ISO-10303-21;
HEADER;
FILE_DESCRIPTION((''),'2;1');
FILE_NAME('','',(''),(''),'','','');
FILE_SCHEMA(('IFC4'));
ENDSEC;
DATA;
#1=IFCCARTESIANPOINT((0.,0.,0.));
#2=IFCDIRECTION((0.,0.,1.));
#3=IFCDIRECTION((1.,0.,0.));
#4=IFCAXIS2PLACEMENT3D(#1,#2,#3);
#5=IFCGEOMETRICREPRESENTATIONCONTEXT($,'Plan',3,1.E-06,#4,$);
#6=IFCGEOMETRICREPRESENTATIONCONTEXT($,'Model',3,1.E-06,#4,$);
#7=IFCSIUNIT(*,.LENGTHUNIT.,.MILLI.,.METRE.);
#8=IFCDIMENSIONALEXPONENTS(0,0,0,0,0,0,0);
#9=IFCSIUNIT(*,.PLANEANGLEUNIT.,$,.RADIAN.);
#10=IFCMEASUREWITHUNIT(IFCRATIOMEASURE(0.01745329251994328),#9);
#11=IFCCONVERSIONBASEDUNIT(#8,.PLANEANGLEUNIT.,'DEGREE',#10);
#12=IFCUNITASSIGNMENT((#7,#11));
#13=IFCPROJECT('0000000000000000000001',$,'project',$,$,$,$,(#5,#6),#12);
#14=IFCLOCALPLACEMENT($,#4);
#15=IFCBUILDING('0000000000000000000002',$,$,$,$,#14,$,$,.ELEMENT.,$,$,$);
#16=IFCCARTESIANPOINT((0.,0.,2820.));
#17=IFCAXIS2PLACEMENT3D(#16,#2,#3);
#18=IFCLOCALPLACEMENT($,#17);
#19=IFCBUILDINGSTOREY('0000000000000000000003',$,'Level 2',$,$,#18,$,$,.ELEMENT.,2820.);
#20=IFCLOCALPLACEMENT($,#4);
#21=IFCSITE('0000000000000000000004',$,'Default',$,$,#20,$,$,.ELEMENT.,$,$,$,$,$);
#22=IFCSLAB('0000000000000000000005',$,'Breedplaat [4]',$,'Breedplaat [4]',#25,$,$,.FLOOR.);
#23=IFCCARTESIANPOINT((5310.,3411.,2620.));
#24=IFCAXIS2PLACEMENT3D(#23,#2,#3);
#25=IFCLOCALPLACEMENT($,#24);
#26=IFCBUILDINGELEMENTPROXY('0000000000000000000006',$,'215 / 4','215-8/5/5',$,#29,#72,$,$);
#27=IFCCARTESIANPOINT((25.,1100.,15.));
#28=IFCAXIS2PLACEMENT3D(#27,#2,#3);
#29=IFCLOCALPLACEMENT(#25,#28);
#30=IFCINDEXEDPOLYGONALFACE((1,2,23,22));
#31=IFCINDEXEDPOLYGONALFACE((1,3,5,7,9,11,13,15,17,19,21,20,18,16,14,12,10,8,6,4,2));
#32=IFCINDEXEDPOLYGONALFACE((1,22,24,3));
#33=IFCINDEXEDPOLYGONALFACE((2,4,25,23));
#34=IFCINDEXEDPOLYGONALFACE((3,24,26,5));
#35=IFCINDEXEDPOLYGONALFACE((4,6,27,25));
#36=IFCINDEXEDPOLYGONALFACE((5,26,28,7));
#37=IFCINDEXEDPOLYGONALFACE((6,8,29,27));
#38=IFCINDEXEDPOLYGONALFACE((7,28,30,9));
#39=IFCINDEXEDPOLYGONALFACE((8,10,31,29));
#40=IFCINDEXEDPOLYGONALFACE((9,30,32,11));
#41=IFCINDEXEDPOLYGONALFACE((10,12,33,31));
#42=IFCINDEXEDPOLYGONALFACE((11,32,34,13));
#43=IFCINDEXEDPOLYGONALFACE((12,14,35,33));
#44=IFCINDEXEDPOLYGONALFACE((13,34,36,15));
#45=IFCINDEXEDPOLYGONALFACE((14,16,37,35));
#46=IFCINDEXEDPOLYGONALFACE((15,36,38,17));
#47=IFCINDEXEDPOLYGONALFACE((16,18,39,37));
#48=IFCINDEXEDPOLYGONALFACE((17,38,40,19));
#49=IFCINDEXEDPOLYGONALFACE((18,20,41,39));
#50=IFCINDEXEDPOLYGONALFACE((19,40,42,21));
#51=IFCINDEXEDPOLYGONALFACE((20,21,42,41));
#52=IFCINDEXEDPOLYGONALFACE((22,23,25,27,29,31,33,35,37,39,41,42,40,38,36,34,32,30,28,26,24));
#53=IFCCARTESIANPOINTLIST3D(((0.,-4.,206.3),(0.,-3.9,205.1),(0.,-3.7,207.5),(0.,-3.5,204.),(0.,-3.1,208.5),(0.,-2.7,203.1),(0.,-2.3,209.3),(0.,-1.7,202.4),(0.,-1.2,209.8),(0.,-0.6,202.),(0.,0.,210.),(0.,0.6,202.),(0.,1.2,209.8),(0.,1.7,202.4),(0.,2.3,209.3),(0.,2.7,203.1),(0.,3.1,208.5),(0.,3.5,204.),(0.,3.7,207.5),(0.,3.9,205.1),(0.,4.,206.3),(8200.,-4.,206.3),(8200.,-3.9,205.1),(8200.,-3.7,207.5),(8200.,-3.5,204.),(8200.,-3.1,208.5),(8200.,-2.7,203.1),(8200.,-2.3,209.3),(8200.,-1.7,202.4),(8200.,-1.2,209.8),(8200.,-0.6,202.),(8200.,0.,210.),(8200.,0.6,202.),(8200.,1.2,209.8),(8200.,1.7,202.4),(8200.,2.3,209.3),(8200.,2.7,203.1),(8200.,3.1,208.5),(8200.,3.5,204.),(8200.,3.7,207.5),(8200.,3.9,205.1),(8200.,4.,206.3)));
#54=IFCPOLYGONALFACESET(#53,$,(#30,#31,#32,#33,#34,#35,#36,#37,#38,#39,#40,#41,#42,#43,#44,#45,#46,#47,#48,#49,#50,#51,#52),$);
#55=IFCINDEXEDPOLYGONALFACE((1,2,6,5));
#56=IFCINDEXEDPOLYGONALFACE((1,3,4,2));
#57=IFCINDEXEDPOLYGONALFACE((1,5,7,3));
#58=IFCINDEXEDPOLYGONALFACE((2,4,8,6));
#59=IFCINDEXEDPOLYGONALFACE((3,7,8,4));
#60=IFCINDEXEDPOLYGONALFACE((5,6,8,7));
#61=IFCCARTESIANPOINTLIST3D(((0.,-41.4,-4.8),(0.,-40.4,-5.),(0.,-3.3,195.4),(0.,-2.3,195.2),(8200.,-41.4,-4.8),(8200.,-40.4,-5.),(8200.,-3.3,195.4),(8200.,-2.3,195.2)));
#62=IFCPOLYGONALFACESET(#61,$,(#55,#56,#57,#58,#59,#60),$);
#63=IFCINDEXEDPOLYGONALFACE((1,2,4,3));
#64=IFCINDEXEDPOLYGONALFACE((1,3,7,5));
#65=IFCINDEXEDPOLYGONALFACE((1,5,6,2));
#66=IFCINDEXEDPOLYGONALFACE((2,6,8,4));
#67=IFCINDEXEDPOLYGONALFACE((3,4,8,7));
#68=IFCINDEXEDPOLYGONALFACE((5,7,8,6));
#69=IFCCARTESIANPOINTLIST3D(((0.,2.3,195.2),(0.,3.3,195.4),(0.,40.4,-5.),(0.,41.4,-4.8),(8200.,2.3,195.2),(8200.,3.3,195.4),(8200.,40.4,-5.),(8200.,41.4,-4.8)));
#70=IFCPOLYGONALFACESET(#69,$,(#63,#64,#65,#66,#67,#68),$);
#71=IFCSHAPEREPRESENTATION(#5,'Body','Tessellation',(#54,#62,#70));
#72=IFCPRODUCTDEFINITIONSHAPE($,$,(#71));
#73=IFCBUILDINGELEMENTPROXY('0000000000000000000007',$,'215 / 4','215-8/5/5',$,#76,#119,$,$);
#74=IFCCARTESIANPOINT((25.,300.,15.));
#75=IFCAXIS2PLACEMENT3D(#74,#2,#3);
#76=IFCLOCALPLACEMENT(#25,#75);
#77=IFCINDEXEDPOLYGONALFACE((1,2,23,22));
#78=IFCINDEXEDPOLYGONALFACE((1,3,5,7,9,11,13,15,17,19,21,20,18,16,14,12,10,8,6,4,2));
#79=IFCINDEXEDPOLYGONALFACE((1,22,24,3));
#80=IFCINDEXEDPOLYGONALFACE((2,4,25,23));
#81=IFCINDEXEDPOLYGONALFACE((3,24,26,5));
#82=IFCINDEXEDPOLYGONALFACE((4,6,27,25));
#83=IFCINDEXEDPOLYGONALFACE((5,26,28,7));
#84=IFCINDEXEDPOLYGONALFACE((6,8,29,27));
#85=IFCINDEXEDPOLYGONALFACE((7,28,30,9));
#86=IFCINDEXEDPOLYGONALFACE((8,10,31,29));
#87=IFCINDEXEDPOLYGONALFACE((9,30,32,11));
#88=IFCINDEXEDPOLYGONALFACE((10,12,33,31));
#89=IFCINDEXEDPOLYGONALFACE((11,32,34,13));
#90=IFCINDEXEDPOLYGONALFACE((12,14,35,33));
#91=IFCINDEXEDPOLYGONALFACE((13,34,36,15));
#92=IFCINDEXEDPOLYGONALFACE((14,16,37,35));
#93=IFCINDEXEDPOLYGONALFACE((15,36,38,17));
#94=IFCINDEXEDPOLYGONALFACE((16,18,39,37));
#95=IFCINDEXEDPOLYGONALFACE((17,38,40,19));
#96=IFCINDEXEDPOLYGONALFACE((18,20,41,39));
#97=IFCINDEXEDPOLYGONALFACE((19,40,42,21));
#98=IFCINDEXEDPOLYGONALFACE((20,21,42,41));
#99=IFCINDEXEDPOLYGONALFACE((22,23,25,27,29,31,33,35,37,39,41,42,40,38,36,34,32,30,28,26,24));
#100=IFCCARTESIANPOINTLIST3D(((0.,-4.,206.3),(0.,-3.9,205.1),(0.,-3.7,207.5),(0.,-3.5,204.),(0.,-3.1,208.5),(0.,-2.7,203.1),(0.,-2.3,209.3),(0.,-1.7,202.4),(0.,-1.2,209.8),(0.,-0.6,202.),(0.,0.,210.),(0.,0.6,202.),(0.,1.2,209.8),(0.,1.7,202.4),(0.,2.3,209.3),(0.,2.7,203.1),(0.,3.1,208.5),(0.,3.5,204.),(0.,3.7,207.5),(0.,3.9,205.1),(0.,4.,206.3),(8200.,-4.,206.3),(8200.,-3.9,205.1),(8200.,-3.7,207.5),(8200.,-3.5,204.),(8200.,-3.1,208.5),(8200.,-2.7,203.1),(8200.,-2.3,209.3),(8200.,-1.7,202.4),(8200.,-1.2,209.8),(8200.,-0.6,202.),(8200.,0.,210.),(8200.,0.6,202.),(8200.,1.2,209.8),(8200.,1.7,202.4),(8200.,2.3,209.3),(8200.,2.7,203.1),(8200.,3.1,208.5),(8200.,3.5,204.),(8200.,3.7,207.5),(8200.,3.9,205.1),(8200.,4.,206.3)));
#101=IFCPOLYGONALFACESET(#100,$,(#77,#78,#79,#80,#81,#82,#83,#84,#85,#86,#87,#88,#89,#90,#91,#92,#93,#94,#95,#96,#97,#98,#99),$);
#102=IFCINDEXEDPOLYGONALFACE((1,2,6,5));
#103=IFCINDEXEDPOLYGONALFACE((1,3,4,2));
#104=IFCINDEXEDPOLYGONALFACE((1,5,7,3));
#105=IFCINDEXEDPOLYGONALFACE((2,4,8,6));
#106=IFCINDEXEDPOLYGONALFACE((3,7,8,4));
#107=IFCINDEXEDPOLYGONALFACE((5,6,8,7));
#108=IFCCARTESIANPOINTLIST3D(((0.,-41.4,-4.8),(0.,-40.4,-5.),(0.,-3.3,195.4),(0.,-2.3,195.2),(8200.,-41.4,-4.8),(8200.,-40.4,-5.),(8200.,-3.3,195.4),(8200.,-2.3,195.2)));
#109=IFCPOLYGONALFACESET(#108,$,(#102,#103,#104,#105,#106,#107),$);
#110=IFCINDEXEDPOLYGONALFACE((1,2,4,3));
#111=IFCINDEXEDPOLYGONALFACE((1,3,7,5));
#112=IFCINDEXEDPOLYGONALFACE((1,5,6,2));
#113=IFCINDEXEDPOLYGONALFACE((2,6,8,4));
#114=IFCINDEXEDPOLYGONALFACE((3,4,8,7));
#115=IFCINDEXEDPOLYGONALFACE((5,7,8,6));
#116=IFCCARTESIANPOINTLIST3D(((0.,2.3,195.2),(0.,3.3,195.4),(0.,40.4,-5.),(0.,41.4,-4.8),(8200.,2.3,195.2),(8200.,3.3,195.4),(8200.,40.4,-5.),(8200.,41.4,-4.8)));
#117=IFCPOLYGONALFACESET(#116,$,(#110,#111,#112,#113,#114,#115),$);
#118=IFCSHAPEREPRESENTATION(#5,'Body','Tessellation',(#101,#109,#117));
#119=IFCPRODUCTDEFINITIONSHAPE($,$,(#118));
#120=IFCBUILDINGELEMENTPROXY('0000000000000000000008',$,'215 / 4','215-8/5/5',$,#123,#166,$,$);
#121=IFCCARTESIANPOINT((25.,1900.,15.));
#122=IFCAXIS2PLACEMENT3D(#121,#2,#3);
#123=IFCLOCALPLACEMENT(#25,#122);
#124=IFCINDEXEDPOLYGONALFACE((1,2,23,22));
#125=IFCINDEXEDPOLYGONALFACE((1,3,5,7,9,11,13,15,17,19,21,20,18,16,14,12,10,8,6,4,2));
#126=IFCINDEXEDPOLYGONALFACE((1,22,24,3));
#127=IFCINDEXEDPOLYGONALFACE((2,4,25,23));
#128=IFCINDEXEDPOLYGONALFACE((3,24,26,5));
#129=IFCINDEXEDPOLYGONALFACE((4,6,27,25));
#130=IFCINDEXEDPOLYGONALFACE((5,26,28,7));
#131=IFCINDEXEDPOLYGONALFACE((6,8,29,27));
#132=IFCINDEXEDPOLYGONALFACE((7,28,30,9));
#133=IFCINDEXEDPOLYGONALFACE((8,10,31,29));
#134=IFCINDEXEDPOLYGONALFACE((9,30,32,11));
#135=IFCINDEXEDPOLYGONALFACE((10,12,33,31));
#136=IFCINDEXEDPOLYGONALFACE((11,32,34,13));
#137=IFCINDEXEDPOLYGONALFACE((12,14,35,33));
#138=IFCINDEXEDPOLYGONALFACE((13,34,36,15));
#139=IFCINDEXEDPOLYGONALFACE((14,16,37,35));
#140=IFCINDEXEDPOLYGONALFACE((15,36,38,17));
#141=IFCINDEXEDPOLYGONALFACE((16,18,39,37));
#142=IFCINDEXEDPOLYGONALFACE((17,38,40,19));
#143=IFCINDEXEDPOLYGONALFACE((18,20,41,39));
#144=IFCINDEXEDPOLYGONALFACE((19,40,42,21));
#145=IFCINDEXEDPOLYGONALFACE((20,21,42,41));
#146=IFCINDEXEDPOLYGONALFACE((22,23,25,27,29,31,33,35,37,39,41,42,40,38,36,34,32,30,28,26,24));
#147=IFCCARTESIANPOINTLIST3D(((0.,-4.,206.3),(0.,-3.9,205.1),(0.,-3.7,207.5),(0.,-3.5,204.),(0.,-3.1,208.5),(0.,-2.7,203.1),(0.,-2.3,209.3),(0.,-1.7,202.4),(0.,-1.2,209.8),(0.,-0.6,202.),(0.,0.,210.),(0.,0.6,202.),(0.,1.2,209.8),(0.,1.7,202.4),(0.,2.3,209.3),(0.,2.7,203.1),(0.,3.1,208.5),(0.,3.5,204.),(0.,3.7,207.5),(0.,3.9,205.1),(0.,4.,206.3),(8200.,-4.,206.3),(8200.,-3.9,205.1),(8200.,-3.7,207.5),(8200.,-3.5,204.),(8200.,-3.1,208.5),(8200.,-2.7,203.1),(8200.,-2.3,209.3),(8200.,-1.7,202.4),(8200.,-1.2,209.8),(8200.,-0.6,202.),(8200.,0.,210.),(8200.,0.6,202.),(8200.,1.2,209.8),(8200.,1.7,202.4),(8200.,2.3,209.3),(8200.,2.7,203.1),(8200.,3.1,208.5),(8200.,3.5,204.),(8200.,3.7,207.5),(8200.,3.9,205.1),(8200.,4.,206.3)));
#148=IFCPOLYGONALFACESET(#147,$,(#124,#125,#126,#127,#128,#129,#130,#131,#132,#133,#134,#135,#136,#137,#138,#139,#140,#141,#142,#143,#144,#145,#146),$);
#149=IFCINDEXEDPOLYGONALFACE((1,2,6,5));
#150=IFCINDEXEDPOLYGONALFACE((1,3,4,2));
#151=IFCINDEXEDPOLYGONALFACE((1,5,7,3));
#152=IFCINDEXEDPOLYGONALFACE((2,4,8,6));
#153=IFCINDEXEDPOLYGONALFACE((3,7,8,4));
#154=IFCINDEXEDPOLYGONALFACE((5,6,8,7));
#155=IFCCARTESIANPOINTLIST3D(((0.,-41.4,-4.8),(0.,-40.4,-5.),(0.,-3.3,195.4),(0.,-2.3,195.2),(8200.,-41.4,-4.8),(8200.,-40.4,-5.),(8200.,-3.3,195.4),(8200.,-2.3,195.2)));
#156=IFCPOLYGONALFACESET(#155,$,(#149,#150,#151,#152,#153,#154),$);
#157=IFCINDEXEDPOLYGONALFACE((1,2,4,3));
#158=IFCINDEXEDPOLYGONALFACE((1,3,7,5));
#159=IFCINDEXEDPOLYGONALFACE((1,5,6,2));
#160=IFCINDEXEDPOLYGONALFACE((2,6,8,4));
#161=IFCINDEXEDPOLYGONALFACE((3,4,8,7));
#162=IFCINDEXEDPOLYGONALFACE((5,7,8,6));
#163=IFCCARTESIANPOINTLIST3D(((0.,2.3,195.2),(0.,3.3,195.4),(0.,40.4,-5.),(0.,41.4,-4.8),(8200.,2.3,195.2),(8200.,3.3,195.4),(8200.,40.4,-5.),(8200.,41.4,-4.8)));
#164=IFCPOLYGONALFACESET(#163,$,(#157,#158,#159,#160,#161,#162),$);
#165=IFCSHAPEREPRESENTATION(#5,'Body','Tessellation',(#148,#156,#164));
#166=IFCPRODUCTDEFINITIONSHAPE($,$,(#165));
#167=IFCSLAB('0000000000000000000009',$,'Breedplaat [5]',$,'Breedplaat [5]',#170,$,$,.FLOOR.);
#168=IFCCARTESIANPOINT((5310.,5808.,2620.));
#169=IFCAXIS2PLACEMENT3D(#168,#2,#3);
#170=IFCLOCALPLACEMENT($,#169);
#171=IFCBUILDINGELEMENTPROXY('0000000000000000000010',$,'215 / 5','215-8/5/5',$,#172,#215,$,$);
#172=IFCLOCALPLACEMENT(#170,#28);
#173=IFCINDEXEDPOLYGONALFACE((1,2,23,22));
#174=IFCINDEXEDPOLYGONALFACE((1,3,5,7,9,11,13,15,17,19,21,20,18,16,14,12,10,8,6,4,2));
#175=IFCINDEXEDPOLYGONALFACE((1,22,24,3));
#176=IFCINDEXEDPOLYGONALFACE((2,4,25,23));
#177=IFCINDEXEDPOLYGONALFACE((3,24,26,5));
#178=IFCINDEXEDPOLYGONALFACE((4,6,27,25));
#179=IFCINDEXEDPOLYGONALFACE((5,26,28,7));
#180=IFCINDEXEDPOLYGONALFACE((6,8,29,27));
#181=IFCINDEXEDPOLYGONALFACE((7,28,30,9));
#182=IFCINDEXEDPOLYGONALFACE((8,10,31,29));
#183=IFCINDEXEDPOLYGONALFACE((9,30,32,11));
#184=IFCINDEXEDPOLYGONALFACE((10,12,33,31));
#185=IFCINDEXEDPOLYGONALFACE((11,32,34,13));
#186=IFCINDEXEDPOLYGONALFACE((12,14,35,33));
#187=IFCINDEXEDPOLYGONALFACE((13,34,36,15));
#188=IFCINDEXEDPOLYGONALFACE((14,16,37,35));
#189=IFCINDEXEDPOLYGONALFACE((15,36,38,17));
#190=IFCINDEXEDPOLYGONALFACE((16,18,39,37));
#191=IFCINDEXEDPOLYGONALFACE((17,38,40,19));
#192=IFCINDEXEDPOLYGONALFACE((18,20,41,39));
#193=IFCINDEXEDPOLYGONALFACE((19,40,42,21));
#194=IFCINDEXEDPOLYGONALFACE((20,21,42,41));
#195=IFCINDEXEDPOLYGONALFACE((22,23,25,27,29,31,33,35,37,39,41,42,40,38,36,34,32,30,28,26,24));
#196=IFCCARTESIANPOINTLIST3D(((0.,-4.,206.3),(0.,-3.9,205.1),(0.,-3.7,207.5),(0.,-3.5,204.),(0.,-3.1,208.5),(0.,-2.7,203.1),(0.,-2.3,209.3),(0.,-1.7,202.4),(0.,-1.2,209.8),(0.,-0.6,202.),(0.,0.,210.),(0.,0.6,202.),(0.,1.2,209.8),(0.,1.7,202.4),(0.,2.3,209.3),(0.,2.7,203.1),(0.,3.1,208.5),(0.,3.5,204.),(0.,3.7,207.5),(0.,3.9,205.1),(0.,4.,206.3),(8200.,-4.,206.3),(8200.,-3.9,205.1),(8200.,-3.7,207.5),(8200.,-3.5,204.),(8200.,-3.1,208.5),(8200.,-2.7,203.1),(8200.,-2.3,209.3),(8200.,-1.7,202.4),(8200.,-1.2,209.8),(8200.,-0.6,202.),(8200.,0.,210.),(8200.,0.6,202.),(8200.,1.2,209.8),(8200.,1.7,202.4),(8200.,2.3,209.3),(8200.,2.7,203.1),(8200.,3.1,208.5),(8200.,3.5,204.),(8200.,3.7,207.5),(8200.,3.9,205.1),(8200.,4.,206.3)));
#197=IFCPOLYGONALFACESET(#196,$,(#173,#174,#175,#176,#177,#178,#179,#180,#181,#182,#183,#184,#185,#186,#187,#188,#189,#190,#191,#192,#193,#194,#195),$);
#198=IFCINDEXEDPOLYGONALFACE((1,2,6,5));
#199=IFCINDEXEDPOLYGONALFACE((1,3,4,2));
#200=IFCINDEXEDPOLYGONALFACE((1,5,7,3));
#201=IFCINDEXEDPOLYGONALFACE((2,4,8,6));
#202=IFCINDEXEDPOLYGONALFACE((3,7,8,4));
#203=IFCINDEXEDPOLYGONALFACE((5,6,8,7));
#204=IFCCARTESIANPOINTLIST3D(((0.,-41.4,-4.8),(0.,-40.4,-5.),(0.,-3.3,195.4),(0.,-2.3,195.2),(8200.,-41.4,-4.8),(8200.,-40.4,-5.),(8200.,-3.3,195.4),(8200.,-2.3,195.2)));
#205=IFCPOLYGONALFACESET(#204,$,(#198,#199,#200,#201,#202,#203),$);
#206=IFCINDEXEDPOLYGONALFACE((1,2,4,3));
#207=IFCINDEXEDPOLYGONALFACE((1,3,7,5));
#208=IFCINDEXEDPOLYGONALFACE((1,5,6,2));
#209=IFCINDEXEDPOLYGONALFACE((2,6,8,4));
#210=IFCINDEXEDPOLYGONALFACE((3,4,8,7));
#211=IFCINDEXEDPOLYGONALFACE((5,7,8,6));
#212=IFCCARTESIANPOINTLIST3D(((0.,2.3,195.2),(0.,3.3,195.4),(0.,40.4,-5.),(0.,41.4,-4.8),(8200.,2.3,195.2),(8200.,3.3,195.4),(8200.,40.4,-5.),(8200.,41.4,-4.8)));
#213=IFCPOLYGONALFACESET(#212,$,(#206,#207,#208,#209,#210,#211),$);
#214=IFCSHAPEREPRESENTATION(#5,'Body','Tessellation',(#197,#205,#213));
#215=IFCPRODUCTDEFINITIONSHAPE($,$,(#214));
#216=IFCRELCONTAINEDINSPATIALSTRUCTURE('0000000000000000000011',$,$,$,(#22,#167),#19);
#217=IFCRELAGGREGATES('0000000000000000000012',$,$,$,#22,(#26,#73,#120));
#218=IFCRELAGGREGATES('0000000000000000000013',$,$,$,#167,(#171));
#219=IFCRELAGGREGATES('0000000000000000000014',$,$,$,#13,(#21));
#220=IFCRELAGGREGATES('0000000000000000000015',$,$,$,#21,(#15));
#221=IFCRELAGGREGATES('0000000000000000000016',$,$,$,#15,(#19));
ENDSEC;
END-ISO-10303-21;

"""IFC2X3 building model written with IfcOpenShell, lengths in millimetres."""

from ifc_helpers import new_model, entity, si_unit, converted_unit, frame, origin_with_axes, origin_2d_with_axis, place, context, project, spatial, rectangle, circle, extrude, element, aggregate, save


model = new_model("IFC2X3")

# Units and contexts
plan_context = context("Plan", 3, precision=1e-06, world=origin_with_axes())
model_context = context("Model", 3, precision=1e-06, world=origin_with_axes())
ifc_project = project(units=[si_unit("LENGTHUNIT", "METRE", prefix="MILLI"), converted_unit("PLANEANGLEUNIT", "DEGREE", entity("IfcRatioMeasure", 0.01745329251994328), si_unit("PLANEANGLEUNIT", "RADIAN"), dimensions=[0, 0, 0, 0, 0, 0, 0])], contexts=[plan_context, model_context])

# Site, building, storey
site_placement = place(None, origin_with_axes())
site = spatial("IfcSite", under=ifc_project, at=site_placement, Name="Default", CompositionType="ELEMENT")
building_placement = place(None, origin_with_axes())
building = spatial("IfcBuilding", under=site, at=building_placement, CompositionType="ELEMENT")
storey_placement = place(None, frame((0.0, 0.0, 2820.0), z_axis=(0.0, 0.0, 1.0), x_axis=(1.0, 0.0, 0.0)))
storey = spatial("IfcBuildingStorey", under=building, at=storey_placement, Name="Level 2", CompositionType="ELEMENT", Elevation=2820.0)

# Slabs, building element proxies
slab_1_placement = place(None, frame((5310.0, 3411.0, 2620.0), z_axis=(0.0, 0.0, 1.0), x_axis=(1.0, 0.0, 0.0)))
slab_1 = element("IfcSlab", 1, at=slab_1_placement, inside=storey, Name="Breedplaat [4]", ObjectType="Breedplaat [4]", PredefinedType="FLOOR")
proxy_1_placement = place(slab_1_placement, frame((25.0, 1100.0, 15.0), z_axis=(0.0, 0.0, 1.0), x_axis=(1.0, 0.0, 0.0)))
proxy_1 = element("IfcBuildingElementProxy", 2, at=proxy_1_placement, Name="215 / 4", Description="215-8/5/5", context=plan_context, shape_type="SweptSolid", body=[
    extrude(circle(Radius=4.0, at=origin_2d_with_axis()), frame((0.0, 0.0, 206.0), z_axis=(1.0, 0.0, 0.0), x_axis=(0.0, 0.0, 1.0)), (0.0, 0.0, 1.0), 8200.0),
    extrude(rectangle(XDim=203.8, YDim=1.0, at=origin_2d_with_axis()), frame((0.0, -21.9, 95.2), z_axis=(1.0, 0.0, 0.0), x_axis=(0.0, 0.187112, 0.982339)), (0.0, 0.0, 1.0), 8200.0),
    extrude(rectangle(XDim=203.8, YDim=1.0, at=origin_2d_with_axis()), frame((0.0, 21.9, 95.2), z_axis=(1.0, 0.0, 0.0), x_axis=(0.0, -0.187112, 0.982339)), (0.0, 0.0, 1.0), 8200.0),
])
proxy_2_placement = place(slab_1_placement, frame((25.0, 300.0, 15.0), z_axis=(0.0, 0.0, 1.0), x_axis=(1.0, 0.0, 0.0)))
proxy_2 = element("IfcBuildingElementProxy", 3, at=proxy_2_placement, Name="215 / 4", Description="215-8/5/5", context=plan_context, shape_type="SweptSolid", body=[
    extrude(circle(Radius=4.0, at=origin_2d_with_axis()), frame((0.0, 0.0, 206.0), z_axis=(1.0, 0.0, 0.0), x_axis=(0.0, 0.0, 1.0)), (0.0, 0.0, 1.0), 8200.0),
    extrude(rectangle(XDim=203.8, YDim=1.0, at=origin_2d_with_axis()), frame((0.0, -21.9, 95.2), z_axis=(1.0, 0.0, 0.0), x_axis=(0.0, 0.187112, 0.982339)), (0.0, 0.0, 1.0), 8200.0),
    extrude(rectangle(XDim=203.8, YDim=1.0, at=origin_2d_with_axis()), frame((0.0, 21.9, 95.2), z_axis=(1.0, 0.0, 0.0), x_axis=(0.0, -0.187112, 0.982339)), (0.0, 0.0, 1.0), 8200.0),
])
proxy_3_placement = place(slab_1_placement, frame((25.0, 1900.0, 15.0), z_axis=(0.0, 0.0, 1.0), x_axis=(1.0, 0.0, 0.0)))
proxy_3 = element("IfcBuildingElementProxy", 4, at=proxy_3_placement, Name="215 / 4", Description="215-8/5/5", context=plan_context, shape_type="SweptSolid", body=[
    extrude(circle(Radius=4.0, at=origin_2d_with_axis()), frame((0.0, 0.0, 206.0), z_axis=(1.0, 0.0, 0.0), x_axis=(0.0, 0.0, 1.0)), (0.0, 0.0, 1.0), 8200.0),
    extrude(rectangle(XDim=203.8, YDim=1.0, at=origin_2d_with_axis()), frame((0.0, -21.9, 95.2), z_axis=(1.0, 0.0, 0.0), x_axis=(0.0, 0.187112, 0.982339)), (0.0, 0.0, 1.0), 8200.0),
    extrude(rectangle(XDim=203.8, YDim=1.0, at=origin_2d_with_axis()), frame((0.0, 21.9, 95.2), z_axis=(1.0, 0.0, 0.0), x_axis=(0.0, -0.187112, 0.982339)), (0.0, 0.0, 1.0), 8200.0),
])
aggregate(slab_1, [proxy_1, proxy_2, proxy_3])
slab_2_placement = place(None, frame((5310.0, 5808.0, 2620.0), z_axis=(0.0, 0.0, 1.0), x_axis=(1.0, 0.0, 0.0)))
slab_2 = element("IfcSlab", 5, at=slab_2_placement, inside=storey, Name="Breedplaat [5]", ObjectType="Breedplaat [5]", PredefinedType="FLOOR")
proxy_4_placement = place(slab_2_placement, frame((25.0, 1100.0, 15.0), z_axis=(0.0, 0.0, 1.0), x_axis=(1.0, 0.0, 0.0)))
proxy_4 = element("IfcBuildingElementProxy", 6, at=proxy_4_placement, Name="215 / 5", Description="215-8/5/5", context=plan_context, shape_type="SweptSolid", body=[
    extrude(circle(Radius=4.0, at=origin_2d_with_axis()), frame((0.0, 0.0, 206.0), z_axis=(1.0, 0.0, 0.0), x_axis=(0.0, 0.0, 1.0)), (0.0, 0.0, 1.0), 8200.0),
    extrude(rectangle(XDim=203.8, YDim=1.0, at=origin_2d_with_axis()), frame((0.0, -21.9, 95.2), z_axis=(1.0, 0.0, 0.0), x_axis=(0.0, 0.187112, 0.982339)), (0.0, 0.0, 1.0), 8200.0),
    extrude(rectangle(XDim=203.8, YDim=1.0, at=origin_2d_with_axis()), frame((0.0, 21.9, 95.2), z_axis=(1.0, 0.0, 0.0), x_axis=(0.0, -0.187112, 0.982339)), (0.0, 0.0, 1.0), 8200.0),
])
aggregate(slab_2, [proxy_4])

save(model, "model.ifc")
